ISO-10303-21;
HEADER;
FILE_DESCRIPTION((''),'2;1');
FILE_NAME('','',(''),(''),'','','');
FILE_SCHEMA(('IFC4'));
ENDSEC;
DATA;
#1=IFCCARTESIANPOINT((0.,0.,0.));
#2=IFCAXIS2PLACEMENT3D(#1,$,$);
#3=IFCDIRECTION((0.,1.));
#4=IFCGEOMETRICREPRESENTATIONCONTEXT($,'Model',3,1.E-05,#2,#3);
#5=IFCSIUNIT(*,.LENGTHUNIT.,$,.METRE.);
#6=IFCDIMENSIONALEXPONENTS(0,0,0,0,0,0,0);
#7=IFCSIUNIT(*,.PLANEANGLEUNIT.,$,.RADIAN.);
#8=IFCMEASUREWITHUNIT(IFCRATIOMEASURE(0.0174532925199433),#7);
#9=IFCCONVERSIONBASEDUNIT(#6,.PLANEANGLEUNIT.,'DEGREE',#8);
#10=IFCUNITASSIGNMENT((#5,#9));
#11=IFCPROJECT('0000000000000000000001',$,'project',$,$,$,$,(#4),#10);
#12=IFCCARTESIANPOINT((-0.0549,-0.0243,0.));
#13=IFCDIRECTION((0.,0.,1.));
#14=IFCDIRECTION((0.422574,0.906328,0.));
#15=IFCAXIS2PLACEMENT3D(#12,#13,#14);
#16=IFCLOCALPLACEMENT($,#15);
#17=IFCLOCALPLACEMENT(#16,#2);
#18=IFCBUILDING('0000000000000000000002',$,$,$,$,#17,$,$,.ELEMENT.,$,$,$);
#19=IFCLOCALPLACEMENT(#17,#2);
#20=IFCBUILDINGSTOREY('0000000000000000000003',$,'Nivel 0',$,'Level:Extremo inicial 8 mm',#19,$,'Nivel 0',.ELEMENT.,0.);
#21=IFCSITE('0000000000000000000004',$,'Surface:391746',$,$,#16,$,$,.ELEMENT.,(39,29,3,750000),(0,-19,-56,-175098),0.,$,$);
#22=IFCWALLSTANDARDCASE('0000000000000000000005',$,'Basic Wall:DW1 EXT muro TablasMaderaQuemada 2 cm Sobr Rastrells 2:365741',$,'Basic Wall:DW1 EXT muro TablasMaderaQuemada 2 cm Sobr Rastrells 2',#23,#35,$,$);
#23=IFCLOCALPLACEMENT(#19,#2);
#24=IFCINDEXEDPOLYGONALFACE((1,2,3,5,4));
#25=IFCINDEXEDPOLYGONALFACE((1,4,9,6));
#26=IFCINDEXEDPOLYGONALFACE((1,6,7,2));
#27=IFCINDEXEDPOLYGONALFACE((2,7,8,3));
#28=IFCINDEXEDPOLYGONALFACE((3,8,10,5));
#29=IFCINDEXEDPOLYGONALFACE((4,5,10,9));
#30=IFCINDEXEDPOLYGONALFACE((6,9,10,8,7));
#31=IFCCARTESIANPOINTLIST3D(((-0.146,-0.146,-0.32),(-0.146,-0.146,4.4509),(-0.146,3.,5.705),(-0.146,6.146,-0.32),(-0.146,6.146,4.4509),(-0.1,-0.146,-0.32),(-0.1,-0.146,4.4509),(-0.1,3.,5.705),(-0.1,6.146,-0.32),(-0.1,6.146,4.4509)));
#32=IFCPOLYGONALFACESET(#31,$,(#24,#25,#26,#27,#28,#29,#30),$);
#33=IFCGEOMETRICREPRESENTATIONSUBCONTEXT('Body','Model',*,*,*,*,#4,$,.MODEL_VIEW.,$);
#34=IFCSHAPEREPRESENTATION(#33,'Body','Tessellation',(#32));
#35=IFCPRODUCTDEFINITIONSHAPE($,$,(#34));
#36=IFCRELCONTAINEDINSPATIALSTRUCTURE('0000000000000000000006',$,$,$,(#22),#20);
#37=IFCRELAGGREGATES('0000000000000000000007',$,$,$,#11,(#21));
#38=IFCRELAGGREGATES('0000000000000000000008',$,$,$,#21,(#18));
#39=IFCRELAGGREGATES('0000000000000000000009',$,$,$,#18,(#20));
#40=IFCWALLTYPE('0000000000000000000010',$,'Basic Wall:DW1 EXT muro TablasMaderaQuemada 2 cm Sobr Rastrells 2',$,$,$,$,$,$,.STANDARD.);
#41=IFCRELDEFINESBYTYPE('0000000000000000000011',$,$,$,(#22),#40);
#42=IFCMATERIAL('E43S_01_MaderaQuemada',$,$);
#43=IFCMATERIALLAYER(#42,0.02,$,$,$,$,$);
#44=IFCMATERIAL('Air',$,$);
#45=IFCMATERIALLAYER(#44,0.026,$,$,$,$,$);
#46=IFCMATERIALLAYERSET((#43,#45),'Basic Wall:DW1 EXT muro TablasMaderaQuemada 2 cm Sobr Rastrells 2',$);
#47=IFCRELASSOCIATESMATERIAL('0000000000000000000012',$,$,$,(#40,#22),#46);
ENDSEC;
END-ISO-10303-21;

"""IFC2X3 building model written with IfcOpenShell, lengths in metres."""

from ifc_helpers import new_model, entity, si_unit, converted_unit, direction, frame, frame_2d, origin, place, context, subcontext, project, spatial, polyline, rectangle, extrude, clip, bounded_halfspace, material, layer, layer_set, layer_usage, type_object, element, save


model = new_model("IFC2X3")

# Units and contexts
model_context = context("Model", 3, precision=1e-05, world=origin(), true_north=direction((0.0, 1.0)))
body_context = subcontext(model_context, "Body", "Model", "MODEL_VIEW")
ifc_project = project(units=[si_unit("LENGTHUNIT", "METRE"), converted_unit("PLANEANGLEUNIT", "DEGREE", entity("IfcRatioMeasure", 0.0174532925199433), si_unit("PLANEANGLEUNIT", "RADIAN"), dimensions=[0, 0, 0, 0, 0, 0, 0])], contexts=[model_context])

# Site, building, storey
site_placement = place(None, frame((-0.0549, -0.0243, 0.0), z_axis=(0.0, 0.0, 1.0), x_axis=(0.422574, 0.906328, 0.0)))
site = spatial("IfcSite", under=ifc_project, at=site_placement, Name="Surface:391746", CompositionType="ELEMENT", RefLatitude=(39, 29, 3, 750000), RefLongitude=(0, -19, -56, -175098), RefElevation=0.0)
building_placement = place(site_placement, origin())
building = spatial("IfcBuilding", under=site, at=building_placement, CompositionType="ELEMENT")
storey_placement = place(building_placement, origin())
storey = spatial("IfcBuildingStorey", under=building, at=storey_placement, Name="Nivel 0", ObjectType="Level:Extremo inicial 8 mm", LongName="Nivel 0", CompositionType="ELEMENT", Elevation=0.0)

# Wall
ifc_material_1 = material(Name="E43S_01_MaderaQuemada")
ifc_layer_1 = layer(ifc_material_1, 0.02)
ifc_material_2 = material(Name="Air")
ifc_layer_2 = layer(ifc_material_2, 0.026)
ifc_layer_set_1 = layer_set([ifc_layer_1, ifc_layer_2], Name="Basic Wall:DW1 EXT muro TablasMaderaQuemada 2 cm Sobr Rastrells 2")
ifc_layer_usage_1 = layer_usage(ifc_layer_set_1, "AXIS2", "NEGATIVE", 0.023)
wall_type_1 = type_object("IfcWallType", Name="Basic Wall:DW1 EXT muro TablasMaderaQuemada 2 cm Sobr Rastrells 2", PredefinedType="STANDARD", material=ifc_layer_set_1)
wall_1_placement = place(storey_placement, frame((-0.123, -0.146, -0.32), z_axis=(0.0, 0.0, 1.0), x_axis=(0.0, 1.0, 0.0)))
element("IfcWallStandardCase", 1, at=wall_1_placement, inside=storey, type_object=wall_type_1, material=ifc_layer_usage_1, Name="Basic Wall:DW1 EXT muro TablasMaderaQuemada 2 cm Sobr Rastrells 2:365741", ObjectType="Basic Wall:DW1 EXT muro TablasMaderaQuemada 2 cm Sobr Rastrells 2", context=body_context, shape_type="Clipping", body=[
    clip(clip(extrude(rectangle(XDim=6.292, YDim=0.046, at=frame_2d((3.146, 0.0), x_axis=(-1.0, 0.0))), origin(), (0.0, 0.0, 1.0), 6.025), bounded_halfspace(frame((0.0, -0.023, 4.7709), z_axis=(-0.370288, 0.0, 0.928917), x_axis=(0.0, -1.0, 0.0)), False, frame((0.0, -0.023, 4.7709)), polyline([(0.0, 0.0), (0.046, 0.0), (3.146, 0.0), (3.146, 0.046), (0.0, 0.046), (0.0, 0.0)]))), bounded_halfspace(frame((3.146, -0.023, 6.025), z_axis=(0.370288, 0.0, 0.928917), x_axis=(0.0, 1.0, 0.0)), False, frame((3.146, -0.023, 6.025)), polyline([(0.0, 0.0), (3.1, 0.0), (3.146, 0.0), (3.146, 0.046), (0.0, 0.046), (0.0, 0.0)]))),
])

save(model, "model.ifc")
